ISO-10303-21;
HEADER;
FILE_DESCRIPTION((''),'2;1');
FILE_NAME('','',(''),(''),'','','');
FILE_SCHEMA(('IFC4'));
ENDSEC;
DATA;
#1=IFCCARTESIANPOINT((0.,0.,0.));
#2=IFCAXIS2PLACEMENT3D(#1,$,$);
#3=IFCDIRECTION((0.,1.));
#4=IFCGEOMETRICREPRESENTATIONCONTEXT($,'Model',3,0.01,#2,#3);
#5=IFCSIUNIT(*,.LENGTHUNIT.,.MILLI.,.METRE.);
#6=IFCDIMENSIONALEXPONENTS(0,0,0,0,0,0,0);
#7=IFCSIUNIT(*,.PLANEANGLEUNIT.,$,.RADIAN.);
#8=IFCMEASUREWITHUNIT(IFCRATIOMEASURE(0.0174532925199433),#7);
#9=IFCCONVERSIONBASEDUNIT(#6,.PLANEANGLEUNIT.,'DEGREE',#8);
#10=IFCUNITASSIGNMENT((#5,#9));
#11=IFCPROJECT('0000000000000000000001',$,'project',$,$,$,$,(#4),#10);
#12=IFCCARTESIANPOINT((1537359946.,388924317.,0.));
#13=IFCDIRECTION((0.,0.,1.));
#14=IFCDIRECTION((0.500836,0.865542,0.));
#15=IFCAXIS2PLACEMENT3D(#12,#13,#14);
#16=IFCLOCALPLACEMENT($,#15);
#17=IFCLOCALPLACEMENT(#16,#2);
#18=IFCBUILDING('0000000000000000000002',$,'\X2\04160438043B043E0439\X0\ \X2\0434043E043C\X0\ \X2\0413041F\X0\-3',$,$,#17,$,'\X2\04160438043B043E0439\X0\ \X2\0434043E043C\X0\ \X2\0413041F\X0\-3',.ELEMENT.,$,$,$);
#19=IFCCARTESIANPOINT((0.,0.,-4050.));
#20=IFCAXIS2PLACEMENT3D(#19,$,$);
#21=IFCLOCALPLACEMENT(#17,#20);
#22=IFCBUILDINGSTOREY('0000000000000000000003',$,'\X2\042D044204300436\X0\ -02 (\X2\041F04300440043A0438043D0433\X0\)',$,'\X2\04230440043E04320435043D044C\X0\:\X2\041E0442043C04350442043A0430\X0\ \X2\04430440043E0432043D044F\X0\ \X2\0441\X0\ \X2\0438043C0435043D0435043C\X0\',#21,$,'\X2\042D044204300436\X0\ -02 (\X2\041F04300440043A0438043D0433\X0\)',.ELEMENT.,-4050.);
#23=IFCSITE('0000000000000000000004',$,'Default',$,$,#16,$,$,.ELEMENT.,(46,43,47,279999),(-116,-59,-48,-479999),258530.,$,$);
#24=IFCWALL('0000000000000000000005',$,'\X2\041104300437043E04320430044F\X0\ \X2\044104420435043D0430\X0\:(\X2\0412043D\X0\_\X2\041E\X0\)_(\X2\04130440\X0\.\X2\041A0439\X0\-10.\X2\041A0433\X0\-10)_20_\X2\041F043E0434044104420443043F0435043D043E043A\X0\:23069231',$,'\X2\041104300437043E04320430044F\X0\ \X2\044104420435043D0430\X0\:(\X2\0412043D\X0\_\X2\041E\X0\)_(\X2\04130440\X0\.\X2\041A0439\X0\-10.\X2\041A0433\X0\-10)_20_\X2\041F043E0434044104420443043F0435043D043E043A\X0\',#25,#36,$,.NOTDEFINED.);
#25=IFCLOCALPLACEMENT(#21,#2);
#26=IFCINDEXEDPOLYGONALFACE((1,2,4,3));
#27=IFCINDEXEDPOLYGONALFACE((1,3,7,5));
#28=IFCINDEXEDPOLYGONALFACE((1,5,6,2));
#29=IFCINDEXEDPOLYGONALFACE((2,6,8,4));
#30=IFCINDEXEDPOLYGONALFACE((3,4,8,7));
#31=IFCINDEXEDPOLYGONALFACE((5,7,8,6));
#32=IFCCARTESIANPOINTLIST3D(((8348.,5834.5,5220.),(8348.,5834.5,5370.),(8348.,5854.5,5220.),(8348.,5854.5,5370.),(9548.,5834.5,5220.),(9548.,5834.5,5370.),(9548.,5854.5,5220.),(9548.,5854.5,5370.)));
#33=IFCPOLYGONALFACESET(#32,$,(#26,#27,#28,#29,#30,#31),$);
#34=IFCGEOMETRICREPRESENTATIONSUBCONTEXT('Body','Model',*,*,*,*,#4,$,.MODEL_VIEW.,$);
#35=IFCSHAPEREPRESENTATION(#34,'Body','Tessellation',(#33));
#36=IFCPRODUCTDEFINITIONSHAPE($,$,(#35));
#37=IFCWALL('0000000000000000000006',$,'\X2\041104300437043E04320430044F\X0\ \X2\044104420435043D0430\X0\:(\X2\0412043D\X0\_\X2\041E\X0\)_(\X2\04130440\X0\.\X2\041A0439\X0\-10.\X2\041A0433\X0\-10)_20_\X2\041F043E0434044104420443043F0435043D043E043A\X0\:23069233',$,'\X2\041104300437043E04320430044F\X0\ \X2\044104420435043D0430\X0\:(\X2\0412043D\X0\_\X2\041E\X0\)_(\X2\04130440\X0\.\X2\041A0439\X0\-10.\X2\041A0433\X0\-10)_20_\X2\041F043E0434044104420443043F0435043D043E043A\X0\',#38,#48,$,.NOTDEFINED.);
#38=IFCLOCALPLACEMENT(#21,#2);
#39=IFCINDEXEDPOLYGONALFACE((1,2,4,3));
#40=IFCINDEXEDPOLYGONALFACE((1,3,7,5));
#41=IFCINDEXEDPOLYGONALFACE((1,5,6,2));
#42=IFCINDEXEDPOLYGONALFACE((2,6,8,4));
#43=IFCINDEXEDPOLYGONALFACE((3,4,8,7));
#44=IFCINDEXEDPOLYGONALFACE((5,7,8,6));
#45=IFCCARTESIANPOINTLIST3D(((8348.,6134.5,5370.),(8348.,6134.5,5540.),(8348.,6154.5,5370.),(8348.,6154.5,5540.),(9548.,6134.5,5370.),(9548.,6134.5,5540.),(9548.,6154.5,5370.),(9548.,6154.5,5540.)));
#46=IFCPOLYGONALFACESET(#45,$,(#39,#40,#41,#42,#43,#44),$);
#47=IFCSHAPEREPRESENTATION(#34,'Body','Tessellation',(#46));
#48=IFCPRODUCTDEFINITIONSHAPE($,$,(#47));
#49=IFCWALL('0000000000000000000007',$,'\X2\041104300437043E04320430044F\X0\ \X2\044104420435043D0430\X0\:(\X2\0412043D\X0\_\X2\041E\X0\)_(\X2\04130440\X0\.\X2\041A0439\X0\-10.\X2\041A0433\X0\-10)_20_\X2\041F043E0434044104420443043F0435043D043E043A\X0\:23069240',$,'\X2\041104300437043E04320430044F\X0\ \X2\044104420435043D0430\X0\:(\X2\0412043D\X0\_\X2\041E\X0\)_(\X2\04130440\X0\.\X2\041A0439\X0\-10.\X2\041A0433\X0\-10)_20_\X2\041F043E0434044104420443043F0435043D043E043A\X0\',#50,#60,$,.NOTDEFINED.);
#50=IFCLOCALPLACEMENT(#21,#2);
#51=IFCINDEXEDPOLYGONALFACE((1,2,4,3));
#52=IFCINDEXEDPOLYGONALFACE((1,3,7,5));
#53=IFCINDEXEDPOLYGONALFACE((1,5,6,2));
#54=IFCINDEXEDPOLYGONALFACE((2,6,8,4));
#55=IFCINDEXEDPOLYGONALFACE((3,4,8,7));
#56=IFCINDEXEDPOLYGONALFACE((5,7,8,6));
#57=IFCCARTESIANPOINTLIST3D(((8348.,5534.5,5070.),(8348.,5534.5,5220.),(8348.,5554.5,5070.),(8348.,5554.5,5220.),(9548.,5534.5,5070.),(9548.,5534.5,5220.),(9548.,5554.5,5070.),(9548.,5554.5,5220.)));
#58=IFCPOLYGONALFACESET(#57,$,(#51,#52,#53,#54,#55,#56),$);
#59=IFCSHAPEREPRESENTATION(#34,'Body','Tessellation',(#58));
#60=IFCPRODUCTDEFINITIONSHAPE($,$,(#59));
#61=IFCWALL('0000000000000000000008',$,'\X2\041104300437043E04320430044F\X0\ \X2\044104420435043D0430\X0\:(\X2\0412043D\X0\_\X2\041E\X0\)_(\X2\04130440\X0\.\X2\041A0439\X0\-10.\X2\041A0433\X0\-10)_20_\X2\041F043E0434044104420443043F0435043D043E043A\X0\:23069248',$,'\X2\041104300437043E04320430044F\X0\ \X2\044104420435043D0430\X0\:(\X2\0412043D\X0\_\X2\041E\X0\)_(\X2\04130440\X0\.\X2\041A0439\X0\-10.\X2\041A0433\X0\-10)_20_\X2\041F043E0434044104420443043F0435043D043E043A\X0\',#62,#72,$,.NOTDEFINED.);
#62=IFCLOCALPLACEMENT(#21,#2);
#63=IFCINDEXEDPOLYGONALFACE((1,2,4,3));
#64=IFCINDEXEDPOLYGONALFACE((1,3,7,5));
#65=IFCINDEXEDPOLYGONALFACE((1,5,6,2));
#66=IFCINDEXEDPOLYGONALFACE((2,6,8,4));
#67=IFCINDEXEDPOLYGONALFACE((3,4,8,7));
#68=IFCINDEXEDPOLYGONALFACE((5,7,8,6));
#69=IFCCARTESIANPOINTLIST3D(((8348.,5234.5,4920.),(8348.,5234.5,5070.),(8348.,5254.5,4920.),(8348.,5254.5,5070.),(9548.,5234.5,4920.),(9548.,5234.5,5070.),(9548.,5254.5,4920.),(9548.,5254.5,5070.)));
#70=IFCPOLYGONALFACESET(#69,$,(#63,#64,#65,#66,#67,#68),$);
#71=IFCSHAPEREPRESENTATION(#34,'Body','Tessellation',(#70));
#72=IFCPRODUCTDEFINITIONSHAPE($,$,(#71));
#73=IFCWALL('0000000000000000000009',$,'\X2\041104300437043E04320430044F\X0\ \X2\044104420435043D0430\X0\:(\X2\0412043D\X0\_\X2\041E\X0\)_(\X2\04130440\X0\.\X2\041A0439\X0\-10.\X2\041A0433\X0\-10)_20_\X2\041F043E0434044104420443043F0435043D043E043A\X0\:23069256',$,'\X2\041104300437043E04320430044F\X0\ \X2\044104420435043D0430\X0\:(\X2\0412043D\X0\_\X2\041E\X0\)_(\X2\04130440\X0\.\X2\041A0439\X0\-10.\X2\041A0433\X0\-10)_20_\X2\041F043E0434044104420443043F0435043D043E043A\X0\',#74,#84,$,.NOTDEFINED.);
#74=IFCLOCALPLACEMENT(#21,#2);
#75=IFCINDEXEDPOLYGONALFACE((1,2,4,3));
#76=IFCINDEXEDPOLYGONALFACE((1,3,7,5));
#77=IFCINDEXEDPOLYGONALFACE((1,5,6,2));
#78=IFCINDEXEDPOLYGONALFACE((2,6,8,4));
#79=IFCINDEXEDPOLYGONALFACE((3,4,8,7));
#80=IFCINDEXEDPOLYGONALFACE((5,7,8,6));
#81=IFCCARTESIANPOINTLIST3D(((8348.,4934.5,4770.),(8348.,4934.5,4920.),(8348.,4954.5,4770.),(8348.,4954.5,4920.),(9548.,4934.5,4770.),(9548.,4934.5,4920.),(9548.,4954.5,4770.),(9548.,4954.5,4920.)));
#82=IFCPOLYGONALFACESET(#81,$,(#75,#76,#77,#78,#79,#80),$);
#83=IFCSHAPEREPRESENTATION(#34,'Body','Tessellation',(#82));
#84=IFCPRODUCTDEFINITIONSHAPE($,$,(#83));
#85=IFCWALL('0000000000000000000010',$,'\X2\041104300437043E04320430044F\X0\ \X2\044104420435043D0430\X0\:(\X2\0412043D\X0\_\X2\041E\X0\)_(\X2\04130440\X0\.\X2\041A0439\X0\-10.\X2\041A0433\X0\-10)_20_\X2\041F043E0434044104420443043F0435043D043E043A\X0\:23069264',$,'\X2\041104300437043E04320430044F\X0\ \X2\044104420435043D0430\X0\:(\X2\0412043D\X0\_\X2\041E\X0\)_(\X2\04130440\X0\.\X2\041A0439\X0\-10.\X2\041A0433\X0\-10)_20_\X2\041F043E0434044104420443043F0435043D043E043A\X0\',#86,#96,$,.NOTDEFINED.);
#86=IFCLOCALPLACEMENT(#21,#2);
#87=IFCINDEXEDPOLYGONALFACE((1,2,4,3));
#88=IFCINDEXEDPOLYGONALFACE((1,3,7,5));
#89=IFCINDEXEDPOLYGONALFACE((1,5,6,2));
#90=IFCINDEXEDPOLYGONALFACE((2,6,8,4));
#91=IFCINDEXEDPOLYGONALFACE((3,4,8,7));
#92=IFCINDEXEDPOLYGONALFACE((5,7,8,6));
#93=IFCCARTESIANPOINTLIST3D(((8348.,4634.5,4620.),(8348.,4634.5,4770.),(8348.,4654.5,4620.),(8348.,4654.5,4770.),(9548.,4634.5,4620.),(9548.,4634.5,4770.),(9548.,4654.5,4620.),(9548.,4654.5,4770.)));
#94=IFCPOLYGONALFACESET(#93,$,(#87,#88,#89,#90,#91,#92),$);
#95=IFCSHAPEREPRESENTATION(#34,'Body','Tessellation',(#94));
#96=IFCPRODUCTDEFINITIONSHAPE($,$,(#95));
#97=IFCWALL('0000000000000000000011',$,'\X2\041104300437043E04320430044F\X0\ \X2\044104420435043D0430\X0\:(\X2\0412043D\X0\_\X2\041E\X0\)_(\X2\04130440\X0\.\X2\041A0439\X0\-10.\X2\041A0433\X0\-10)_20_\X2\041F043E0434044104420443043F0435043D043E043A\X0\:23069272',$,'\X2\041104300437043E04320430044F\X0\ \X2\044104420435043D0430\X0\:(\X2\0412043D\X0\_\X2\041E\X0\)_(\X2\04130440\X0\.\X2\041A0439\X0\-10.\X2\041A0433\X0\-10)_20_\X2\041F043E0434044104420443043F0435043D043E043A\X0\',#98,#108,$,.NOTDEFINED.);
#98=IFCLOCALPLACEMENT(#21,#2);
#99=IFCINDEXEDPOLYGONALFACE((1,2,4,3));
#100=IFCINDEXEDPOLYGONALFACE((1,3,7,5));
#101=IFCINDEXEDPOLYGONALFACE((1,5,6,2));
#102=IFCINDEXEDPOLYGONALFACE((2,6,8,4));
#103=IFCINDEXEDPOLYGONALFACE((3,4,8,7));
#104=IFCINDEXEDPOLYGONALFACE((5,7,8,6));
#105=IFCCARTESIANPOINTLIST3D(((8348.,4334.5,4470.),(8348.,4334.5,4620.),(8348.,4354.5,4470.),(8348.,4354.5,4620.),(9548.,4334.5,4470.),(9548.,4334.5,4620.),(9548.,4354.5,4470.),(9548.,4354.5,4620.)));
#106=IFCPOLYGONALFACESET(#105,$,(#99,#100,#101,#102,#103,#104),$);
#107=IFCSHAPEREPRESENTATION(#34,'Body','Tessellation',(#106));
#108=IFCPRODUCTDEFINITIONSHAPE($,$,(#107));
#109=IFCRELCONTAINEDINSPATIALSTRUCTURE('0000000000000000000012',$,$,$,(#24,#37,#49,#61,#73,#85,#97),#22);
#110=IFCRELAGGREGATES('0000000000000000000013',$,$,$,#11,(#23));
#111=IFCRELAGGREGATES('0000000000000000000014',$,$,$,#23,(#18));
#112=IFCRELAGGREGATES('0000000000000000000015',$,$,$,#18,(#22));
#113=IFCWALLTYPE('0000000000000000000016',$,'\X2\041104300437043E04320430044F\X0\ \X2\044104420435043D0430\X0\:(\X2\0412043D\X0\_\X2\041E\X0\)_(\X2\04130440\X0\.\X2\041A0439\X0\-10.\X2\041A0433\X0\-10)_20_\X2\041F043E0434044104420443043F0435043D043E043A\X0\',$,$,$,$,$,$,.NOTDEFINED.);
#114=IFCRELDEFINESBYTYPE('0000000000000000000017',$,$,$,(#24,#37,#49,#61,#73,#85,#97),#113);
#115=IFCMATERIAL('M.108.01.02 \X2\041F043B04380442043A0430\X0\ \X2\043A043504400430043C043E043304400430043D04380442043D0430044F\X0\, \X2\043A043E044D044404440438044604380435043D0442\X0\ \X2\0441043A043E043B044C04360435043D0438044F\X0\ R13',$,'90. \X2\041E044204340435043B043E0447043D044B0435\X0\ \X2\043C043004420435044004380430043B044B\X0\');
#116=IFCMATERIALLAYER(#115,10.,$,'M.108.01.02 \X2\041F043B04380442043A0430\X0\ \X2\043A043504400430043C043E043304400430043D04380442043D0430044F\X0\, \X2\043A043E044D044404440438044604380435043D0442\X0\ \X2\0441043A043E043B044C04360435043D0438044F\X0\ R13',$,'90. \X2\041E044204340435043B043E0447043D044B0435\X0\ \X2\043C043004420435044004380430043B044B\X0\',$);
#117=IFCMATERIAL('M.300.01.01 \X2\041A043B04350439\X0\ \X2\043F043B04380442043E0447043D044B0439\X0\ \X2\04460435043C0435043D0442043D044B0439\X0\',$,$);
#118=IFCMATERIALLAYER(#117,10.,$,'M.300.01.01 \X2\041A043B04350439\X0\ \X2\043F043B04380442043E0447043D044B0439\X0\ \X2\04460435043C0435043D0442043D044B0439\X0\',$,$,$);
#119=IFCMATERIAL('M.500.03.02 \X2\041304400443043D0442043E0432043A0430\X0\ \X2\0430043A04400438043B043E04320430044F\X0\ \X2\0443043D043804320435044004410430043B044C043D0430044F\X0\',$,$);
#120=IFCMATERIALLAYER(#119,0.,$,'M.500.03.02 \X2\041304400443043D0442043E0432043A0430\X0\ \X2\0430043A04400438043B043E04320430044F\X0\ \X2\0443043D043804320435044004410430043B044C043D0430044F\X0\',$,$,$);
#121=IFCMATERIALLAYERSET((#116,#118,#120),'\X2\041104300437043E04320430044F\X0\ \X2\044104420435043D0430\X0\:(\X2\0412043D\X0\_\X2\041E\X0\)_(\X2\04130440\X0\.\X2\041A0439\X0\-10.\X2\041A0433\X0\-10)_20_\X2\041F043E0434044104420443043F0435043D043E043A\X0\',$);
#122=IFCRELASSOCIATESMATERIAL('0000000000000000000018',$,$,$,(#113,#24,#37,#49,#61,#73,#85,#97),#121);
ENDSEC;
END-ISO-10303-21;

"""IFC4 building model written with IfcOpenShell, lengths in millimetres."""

from ifc_helpers import new_model, entity, si_unit, converted_unit, direction, frame, frame_2d, origin, place, context, subcontext, project, spatial, rectangle, extrude, material, layer, layer_set, layer_usage, type_object, element, save


model = new_model("IFC4")

# Units and contexts
model_context = context("Model", 3, precision=0.01, world=origin(), true_north=direction((0.0, 1.0)))
body_context = subcontext(model_context, "Body", "Model", "MODEL_VIEW")
ifc_project = project(units=[si_unit("LENGTHUNIT", "METRE", prefix="MILLI"), converted_unit("PLANEANGLEUNIT", "DEGREE", entity("IfcRatioMeasure", 0.0174532925199433), si_unit("PLANEANGLEUNIT", "RADIAN"), dimensions=[0, 0, 0, 0, 0, 0, 0])], contexts=[model_context])

# Site, building, storey
site_placement = place(None, frame((1537359946.0, 388924317.0, 0.0), z_axis=(0.0, 0.0, 1.0), x_axis=(0.500836, 0.865542, 0.0)))
site = spatial("IfcSite", under=ifc_project, at=site_placement, Name="Default", CompositionType="ELEMENT", RefLatitude=(46, 43, 47, 279999), RefLongitude=(-116, -59, -48, -479999), RefElevation=258530.0)
building_placement = place(site_placement, origin())
building = spatial("IfcBuilding", under=site, at=building_placement, Name="Жилой дом ГП-3", LongName="Жилой дом ГП-3", CompositionType="ELEMENT")
storey_placement = place(building_placement, frame((0.0, 0.0, -4050.0)))
storey = spatial("IfcBuildingStorey", under=building, at=storey_placement, Name="Этаж -02 (Паркинг)", ObjectType="Уровень:Отметка уровня с именем", LongName="Этаж -02 (Паркинг)", CompositionType="ELEMENT", Elevation=-4050.0)

# Walls
ifc_material_1 = material(Name="M.108.01.02 Плитка керамогранитная, коэффициент скольжения R13", Category="90. Отделочные материалы")
ifc_layer_1 = layer(ifc_material_1, 10.0, Name="M.108.01.02 Плитка керамогранитная, коэффициент скольжения R13", Category="90. Отделочные материалы")
ifc_material_2 = material(Name="M.300.01.01 Клей плиточный цементный")
ifc_layer_2 = layer(ifc_material_2, 10.0, Name="M.300.01.01 Клей плиточный цементный")
ifc_material_3 = material(Name="M.500.03.02 Грунтовка акриловая универсальная")
ifc_layer_3 = layer(ifc_material_3, 0.0, Name="M.500.03.02 Грунтовка акриловая универсальная")
ifc_layer_set = layer_set([ifc_layer_1, ifc_layer_2, ifc_layer_3], Name="Базовая стена:(Вн_О)_(Гр.Кй-10.Кг-10)_20_Подступенок")
ifc_layer_usage_1 = layer_usage(ifc_layer_set, "AXIS2", "NEGATIVE", 10.0)
wall_type = type_object("IfcWallType", Name="Базовая стена:(Вн_О)_(Гр.Кй-10.Кг-10)_20_Подступенок", PredefinedType="NOTDEFINED", material=ifc_layer_set)
wall_1_placement = place(storey_placement, frame((9548.0, 5844.5, 5220.0), z_axis=(0.0, 0.0, 1.0), x_axis=(-1.0, 0.0, 0.0)))
element("IfcWall", 1, at=wall_1_placement, inside=storey, type_object=wall_type, material=ifc_layer_usage_1, Name="Базовая стена:(Вн_О)_(Гр.Кй-10.Кг-10)_20_Подступенок:23069231", ObjectType="Базовая стена:(Вн_О)_(Гр.Кй-10.Кг-10)_20_Подступенок", PredefinedType="NOTDEFINED", context=body_context, shape_type="SweptSolid", body=[
    extrude(rectangle(XDim=1200.0, YDim=20.0, at=frame_2d((600.0, 0.0), x_axis=(-1.0, 0.0))), origin(), (0.0, 0.0, 1.0), 150.0),
])
ifc_layer_usage_2 = layer_usage(ifc_layer_set, "AXIS2", "NEGATIVE", 10.0)
wall_2_placement = place(storey_placement, frame((9548.0, 6144.5, 5370.0), z_axis=(0.0, 0.0, 1.0), x_axis=(-1.0, 0.0, 0.0)))
element("IfcWall", 2, at=wall_2_placement, inside=storey, type_object=wall_type, material=ifc_layer_usage_2, Name="Базовая стена:(Вн_О)_(Гр.Кй-10.Кг-10)_20_Подступенок:23069233", ObjectType="Базовая стена:(Вн_О)_(Гр.Кй-10.Кг-10)_20_Подступенок", PredefinedType="NOTDEFINED", context=body_context, shape_type="SweptSolid", body=[
    extrude(rectangle(XDim=1200.0, YDim=20.0, at=frame_2d((600.0, 0.0), x_axis=(-1.0, 0.0))), origin(), (0.0, 0.0, 1.0), 170.0),
])
ifc_layer_usage_3 = layer_usage(ifc_layer_set, "AXIS2", "NEGATIVE", 10.0)
wall_3_placement = place(storey_placement, frame((9548.0, 5544.5, 5070.0), z_axis=(0.0, 0.0, 1.0), x_axis=(-1.0, 0.0, 0.0)))
element("IfcWall", 3, at=wall_3_placement, inside=storey, type_object=wall_type, material=ifc_layer_usage_3, Name="Базовая стена:(Вн_О)_(Гр.Кй-10.Кг-10)_20_Подступенок:23069240", ObjectType="Базовая стена:(Вн_О)_(Гр.Кй-10.Кг-10)_20_Подступенок", PredefinedType="NOTDEFINED", context=body_context, shape_type="SweptSolid", body=[
    extrude(rectangle(XDim=1200.0, YDim=20.0, at=frame_2d((600.0, 0.0), x_axis=(-1.0, 0.0))), origin(), (0.0, 0.0, 1.0), 150.0),
])
ifc_layer_usage_4 = layer_usage(ifc_layer_set, "AXIS2", "NEGATIVE", 10.0)
wall_4_placement = place(storey_placement, frame((9548.0, 5244.5, 4920.0), z_axis=(0.0, 0.0, 1.0), x_axis=(-1.0, 0.0, 0.0)))
element("IfcWall", 4, at=wall_4_placement, inside=storey, type_object=wall_type, material=ifc_layer_usage_4, Name="Базовая стена:(Вн_О)_(Гр.Кй-10.Кг-10)_20_Подступенок:23069248", ObjectType="Базовая стена:(Вн_О)_(Гр.Кй-10.Кг-10)_20_Подступенок", PredefinedType="NOTDEFINED", context=body_context, shape_type="SweptSolid", body=[
    extrude(rectangle(XDim=1200.0, YDim=20.0, at=frame_2d((600.0, 0.0), x_axis=(-1.0, 0.0))), origin(), (0.0, 0.0, 1.0), 150.0),
])
ifc_layer_usage_5 = layer_usage(ifc_layer_set, "AXIS2", "NEGATIVE", 10.0)
wall_5_placement = place(storey_placement, frame((9548.0, 4944.5, 4770.0), z_axis=(0.0, 0.0, 1.0), x_axis=(-1.0, 0.0, 0.0)))
element("IfcWall", 5, at=wall_5_placement, inside=storey, type_object=wall_type, material=ifc_layer_usage_5, Name="Базовая стена:(Вн_О)_(Гр.Кй-10.Кг-10)_20_Подступенок:23069256", ObjectType="Базовая стена:(Вн_О)_(Гр.Кй-10.Кг-10)_20_Подступенок", PredefinedType="NOTDEFINED", context=body_context, shape_type="SweptSolid", body=[
    extrude(rectangle(XDim=1200.0, YDim=20.0, at=frame_2d((600.0, 0.0), x_axis=(-1.0, 0.0))), origin(), (0.0, 0.0, 1.0), 150.0),
])
ifc_layer_usage_6 = layer_usage(ifc_layer_set, "AXIS2", "NEGATIVE", 10.0)
wall_6_placement = place(storey_placement, frame((9548.0, 4644.5, 4620.0), z_axis=(0.0, 0.0, 1.0), x_axis=(-1.0, 0.0, 0.0)))
element("IfcWall", 6, at=wall_6_placement, inside=storey, type_object=wall_type, material=ifc_layer_usage_6, Name="Базовая стена:(Вн_О)_(Гр.Кй-10.Кг-10)_20_Подступенок:23069264", ObjectType="Базовая стена:(Вн_О)_(Гр.Кй-10.Кг-10)_20_Подступенок", PredefinedType="NOTDEFINED", context=body_context, shape_type="SweptSolid", body=[
    extrude(rectangle(XDim=1200.0, YDim=20.0, at=frame_2d((600.0, 0.0), x_axis=(-1.0, 0.0))), origin(), (0.0, 0.0, 1.0), 150.0),
])
ifc_layer_usage_7 = layer_usage(ifc_layer_set, "AXIS2", "NEGATIVE", 10.0)
wall_7_placement = place(storey_placement, frame((9548.0, 4344.5, 4470.0), z_axis=(0.0, 0.0, 1.0), x_axis=(-1.0, 0.0, 0.0)))
element("IfcWall", 7, at=wall_7_placement, inside=storey, type_object=wall_type, material=ifc_layer_usage_7, Name="Базовая стена:(Вн_О)_(Гр.Кй-10.Кг-10)_20_Подступенок:23069272", ObjectType="Базовая стена:(Вн_О)_(Гр.Кй-10.Кг-10)_20_Подступенок", PredefinedType="NOTDEFINED", context=body_context, shape_type="SweptSolid", body=[
    extrude(rectangle(XDim=1200.0, YDim=20.0, at=frame_2d((600.0, 0.0), x_axis=(-1.0, 0.0))), origin(), (0.0, 0.0, 1.0), 150.0),
])

save(model, "model.ifc")
